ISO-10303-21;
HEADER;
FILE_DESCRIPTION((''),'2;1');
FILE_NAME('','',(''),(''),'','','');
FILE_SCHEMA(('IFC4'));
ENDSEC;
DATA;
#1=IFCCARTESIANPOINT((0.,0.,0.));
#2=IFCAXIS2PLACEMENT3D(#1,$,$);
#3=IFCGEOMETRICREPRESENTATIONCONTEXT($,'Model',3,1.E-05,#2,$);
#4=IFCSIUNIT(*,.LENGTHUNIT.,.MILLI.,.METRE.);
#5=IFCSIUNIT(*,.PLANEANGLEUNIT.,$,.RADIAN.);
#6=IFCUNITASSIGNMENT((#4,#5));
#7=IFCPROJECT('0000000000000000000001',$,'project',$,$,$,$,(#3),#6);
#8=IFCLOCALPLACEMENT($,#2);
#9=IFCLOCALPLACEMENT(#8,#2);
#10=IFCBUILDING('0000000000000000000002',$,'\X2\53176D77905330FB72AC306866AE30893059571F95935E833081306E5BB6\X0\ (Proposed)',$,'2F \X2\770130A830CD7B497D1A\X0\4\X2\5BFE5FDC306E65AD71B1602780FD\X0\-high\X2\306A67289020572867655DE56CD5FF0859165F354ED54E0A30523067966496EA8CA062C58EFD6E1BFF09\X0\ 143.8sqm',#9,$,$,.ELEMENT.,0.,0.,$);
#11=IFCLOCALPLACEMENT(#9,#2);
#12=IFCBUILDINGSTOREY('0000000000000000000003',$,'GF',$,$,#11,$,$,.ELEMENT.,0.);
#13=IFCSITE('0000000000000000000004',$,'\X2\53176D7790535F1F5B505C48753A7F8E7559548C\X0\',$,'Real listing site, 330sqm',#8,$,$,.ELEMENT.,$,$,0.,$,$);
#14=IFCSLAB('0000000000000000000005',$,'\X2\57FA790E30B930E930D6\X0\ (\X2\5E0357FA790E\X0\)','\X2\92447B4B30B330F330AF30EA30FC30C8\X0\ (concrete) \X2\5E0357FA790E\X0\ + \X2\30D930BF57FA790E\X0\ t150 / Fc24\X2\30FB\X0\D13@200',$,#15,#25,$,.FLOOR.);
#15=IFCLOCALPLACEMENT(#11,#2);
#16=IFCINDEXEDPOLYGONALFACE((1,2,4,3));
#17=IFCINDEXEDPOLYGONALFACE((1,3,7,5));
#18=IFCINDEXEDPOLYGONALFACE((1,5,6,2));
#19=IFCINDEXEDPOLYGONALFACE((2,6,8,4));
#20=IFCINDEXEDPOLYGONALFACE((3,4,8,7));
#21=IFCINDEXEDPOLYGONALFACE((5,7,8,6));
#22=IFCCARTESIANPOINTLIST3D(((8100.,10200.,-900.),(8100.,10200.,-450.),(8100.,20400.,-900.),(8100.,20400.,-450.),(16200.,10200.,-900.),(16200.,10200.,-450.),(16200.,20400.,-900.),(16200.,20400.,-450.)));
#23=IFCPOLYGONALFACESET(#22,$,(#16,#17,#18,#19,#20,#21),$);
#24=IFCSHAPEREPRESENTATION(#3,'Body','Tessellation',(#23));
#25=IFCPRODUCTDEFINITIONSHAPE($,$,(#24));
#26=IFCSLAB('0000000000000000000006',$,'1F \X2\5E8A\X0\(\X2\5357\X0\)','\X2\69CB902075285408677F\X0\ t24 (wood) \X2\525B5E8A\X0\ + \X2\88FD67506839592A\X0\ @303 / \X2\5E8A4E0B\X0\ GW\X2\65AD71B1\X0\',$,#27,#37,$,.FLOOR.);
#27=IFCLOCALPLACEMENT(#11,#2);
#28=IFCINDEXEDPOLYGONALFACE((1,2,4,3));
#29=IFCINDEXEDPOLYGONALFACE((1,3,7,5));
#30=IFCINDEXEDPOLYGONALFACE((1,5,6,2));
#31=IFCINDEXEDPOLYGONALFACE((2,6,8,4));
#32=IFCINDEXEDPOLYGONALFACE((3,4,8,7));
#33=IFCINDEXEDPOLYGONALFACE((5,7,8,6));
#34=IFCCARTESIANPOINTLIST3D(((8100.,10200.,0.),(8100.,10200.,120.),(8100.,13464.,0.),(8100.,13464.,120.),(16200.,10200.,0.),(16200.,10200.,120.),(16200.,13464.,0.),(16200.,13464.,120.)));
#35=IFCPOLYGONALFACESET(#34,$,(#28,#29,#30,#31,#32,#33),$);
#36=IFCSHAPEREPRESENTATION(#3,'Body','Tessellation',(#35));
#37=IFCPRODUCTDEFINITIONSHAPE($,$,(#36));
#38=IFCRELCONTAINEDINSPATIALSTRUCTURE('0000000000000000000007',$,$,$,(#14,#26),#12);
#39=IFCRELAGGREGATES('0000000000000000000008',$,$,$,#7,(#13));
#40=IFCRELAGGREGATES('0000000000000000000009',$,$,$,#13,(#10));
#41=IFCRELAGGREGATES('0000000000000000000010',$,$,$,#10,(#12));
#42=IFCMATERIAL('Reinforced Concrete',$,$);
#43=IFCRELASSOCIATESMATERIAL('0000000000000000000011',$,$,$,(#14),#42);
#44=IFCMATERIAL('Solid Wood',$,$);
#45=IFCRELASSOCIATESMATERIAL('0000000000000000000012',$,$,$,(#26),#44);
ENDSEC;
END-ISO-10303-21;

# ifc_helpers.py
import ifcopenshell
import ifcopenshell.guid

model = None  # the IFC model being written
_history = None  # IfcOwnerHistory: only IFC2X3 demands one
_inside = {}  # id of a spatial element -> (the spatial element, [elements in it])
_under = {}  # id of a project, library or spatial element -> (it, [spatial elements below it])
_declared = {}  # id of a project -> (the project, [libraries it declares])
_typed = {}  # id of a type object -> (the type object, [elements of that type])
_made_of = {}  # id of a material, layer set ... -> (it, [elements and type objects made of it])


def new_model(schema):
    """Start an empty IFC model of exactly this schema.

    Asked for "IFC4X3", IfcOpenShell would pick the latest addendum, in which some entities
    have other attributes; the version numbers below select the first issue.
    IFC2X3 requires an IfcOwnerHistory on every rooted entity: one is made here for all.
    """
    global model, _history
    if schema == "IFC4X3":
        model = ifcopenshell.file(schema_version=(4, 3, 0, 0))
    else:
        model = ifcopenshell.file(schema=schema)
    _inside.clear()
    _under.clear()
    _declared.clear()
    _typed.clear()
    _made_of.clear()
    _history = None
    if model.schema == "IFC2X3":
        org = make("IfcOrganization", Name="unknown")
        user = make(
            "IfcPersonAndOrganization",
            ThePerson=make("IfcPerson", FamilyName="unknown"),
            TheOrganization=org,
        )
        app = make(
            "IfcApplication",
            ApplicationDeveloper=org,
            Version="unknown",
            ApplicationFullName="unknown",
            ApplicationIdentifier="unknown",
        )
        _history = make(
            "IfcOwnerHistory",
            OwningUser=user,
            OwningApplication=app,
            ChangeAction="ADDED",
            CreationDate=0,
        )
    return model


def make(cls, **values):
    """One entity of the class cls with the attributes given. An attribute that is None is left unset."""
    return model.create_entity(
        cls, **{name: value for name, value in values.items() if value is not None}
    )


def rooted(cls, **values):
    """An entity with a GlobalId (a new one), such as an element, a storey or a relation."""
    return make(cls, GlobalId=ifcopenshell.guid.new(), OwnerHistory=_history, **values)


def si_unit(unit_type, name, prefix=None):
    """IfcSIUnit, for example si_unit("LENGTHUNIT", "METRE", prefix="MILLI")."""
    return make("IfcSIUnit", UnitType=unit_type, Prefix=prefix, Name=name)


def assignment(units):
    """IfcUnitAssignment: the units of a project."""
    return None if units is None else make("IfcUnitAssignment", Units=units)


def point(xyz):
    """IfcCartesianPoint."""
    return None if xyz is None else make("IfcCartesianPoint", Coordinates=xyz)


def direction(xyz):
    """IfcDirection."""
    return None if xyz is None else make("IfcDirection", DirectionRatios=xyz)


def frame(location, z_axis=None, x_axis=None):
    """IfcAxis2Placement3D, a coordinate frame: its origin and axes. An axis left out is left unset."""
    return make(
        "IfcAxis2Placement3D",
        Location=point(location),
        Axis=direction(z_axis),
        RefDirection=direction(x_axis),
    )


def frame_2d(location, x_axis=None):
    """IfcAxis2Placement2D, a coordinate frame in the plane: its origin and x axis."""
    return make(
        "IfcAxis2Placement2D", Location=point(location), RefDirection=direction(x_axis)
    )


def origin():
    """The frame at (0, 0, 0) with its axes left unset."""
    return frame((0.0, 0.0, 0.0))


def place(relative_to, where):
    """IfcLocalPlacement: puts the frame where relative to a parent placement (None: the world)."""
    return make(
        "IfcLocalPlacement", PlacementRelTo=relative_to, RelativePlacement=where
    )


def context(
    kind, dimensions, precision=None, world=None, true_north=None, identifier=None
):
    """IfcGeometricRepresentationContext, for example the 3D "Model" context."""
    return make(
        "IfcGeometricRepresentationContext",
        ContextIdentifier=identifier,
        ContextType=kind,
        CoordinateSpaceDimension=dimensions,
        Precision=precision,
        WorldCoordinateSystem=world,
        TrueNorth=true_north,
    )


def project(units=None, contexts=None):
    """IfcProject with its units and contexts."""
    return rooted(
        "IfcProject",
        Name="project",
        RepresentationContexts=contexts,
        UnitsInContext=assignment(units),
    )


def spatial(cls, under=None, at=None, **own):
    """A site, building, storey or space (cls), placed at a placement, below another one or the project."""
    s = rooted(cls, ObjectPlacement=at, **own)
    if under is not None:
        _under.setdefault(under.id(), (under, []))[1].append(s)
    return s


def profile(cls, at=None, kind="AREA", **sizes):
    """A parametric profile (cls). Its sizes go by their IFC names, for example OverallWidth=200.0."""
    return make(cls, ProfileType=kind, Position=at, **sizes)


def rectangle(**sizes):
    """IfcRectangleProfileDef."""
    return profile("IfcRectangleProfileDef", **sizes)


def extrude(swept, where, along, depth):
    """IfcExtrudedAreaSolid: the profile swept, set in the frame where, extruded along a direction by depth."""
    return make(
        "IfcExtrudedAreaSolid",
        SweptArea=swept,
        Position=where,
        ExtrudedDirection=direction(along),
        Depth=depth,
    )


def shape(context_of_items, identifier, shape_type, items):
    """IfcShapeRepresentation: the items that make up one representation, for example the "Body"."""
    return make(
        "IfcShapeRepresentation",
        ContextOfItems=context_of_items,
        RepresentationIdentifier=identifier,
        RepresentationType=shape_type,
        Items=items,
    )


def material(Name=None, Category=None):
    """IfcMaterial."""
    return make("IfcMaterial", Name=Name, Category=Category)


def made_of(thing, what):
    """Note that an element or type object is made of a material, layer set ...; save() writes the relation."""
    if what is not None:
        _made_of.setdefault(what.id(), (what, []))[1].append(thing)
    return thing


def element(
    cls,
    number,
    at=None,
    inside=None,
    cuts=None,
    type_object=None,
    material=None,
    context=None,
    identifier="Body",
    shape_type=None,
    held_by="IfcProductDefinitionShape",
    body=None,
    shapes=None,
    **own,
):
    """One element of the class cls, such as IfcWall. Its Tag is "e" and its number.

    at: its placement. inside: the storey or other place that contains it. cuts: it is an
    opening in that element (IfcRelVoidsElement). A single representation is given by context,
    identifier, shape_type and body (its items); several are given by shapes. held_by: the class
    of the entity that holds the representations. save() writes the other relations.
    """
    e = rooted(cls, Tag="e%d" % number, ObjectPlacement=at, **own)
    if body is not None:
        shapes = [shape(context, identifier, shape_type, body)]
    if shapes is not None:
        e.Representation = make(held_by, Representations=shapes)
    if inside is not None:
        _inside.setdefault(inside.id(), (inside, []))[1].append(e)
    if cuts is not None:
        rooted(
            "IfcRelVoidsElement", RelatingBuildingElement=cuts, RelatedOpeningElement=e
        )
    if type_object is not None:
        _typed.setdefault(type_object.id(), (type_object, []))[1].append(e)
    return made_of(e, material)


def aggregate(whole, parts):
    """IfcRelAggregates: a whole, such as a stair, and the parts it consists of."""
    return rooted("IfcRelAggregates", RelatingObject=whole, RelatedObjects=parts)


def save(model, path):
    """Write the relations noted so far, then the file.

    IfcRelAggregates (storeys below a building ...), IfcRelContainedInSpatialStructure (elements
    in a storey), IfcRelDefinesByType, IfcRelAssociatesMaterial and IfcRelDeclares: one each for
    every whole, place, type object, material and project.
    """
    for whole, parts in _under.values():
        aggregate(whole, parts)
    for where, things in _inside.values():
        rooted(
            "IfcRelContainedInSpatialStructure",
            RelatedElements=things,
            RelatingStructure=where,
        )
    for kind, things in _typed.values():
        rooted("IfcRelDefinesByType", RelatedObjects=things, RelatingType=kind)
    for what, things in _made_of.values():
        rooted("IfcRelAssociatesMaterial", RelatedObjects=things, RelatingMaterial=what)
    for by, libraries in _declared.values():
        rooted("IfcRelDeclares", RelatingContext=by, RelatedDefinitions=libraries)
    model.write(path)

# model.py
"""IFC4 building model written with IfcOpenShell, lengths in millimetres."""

from ifc_helpers import new_model, si_unit, frame, frame_2d, origin, place, context, project, spatial, rectangle, extrude, material, element, save


model = new_model("IFC4")

# Units and contexts
model_context = context("Model", 3, precision=1e-05, world=origin())
ifc_project = project(units=[si_unit("LENGTHUNIT", "METRE", prefix="MILLI"), si_unit("PLANEANGLEUNIT", "RADIAN")], contexts=[model_context])

# Site, building, storey
site_placement = place(None, origin())
site = spatial("IfcSite", under=ifc_project, at=site_placement, Name="北海道弟子屈町美留和", ObjectType="Real listing site, 330sqm", CompositionType="ELEMENT", RefElevation=0.0)
building_placement = place(site_placement, origin())
building = spatial("IfcBuilding", under=site, at=building_placement, Name="北海道・犬と暮らす土間広めの家 (Proposed)", ObjectType="2F 省エネ等級4対応の断熱性能-highな木造在来工法（外張仕上げで除雪負担軽減） 143.8sqm", CompositionType="ELEMENT", ElevationOfRefHeight=0.0, ElevationOfTerrain=0.0)
storey_placement = place(building_placement, origin())
storey = spatial("IfcBuildingStorey", under=building, at=storey_placement, Name="GF", CompositionType="ELEMENT", Elevation=0.0)

# Shared definitions
ifc_material_1 = material(Name="Solid Wood")

# Slabs
ifc_material_2 = material(Name="Reinforced Concrete")
slab_1_placement = place(storey_placement, frame((4050.0, 5100.0, -450.0)))
element("IfcSlab", 1, at=slab_1_placement, inside=storey, material=ifc_material_2, Name="基礎スラブ (布基礎)", Description="鉄筋コンクリート (concrete) 布基礎 + ベタ基礎 t150 / Fc24・D13@200", PredefinedType="FLOOR", context=model_context, shape_type="SweptSolid", body=[
    extrude(rectangle(XDim=8100.0, YDim=10200.0, at=frame_2d((4050.0, 5100.0))), frame((4050.0, 5100.0, -450.0)), (0.0, 0.0, 1.0), 450.0),
])
slab_2_placement = place(storey_placement, frame((4050.0, 5100.0, 0.0)))
element("IfcSlab", 2, at=slab_2_placement, inside=storey, material=ifc_material_1, Name="1F 床(南)", Description="構造用合板 t24 (wood) 剛床 + 製材根太 @303 / 床下 GW断熱", PredefinedType="FLOOR", context=model_context, shape_type="SweptSolid", body=[
    extrude(rectangle(XDim=8100.0, YDim=3264.0, at=frame_2d((4050.0, 1632.0))), frame((4050.0, 5100.0, 0.0)), (0.0, 0.0, 1.0), 120.0),
])

save(model, "model.ifc")
